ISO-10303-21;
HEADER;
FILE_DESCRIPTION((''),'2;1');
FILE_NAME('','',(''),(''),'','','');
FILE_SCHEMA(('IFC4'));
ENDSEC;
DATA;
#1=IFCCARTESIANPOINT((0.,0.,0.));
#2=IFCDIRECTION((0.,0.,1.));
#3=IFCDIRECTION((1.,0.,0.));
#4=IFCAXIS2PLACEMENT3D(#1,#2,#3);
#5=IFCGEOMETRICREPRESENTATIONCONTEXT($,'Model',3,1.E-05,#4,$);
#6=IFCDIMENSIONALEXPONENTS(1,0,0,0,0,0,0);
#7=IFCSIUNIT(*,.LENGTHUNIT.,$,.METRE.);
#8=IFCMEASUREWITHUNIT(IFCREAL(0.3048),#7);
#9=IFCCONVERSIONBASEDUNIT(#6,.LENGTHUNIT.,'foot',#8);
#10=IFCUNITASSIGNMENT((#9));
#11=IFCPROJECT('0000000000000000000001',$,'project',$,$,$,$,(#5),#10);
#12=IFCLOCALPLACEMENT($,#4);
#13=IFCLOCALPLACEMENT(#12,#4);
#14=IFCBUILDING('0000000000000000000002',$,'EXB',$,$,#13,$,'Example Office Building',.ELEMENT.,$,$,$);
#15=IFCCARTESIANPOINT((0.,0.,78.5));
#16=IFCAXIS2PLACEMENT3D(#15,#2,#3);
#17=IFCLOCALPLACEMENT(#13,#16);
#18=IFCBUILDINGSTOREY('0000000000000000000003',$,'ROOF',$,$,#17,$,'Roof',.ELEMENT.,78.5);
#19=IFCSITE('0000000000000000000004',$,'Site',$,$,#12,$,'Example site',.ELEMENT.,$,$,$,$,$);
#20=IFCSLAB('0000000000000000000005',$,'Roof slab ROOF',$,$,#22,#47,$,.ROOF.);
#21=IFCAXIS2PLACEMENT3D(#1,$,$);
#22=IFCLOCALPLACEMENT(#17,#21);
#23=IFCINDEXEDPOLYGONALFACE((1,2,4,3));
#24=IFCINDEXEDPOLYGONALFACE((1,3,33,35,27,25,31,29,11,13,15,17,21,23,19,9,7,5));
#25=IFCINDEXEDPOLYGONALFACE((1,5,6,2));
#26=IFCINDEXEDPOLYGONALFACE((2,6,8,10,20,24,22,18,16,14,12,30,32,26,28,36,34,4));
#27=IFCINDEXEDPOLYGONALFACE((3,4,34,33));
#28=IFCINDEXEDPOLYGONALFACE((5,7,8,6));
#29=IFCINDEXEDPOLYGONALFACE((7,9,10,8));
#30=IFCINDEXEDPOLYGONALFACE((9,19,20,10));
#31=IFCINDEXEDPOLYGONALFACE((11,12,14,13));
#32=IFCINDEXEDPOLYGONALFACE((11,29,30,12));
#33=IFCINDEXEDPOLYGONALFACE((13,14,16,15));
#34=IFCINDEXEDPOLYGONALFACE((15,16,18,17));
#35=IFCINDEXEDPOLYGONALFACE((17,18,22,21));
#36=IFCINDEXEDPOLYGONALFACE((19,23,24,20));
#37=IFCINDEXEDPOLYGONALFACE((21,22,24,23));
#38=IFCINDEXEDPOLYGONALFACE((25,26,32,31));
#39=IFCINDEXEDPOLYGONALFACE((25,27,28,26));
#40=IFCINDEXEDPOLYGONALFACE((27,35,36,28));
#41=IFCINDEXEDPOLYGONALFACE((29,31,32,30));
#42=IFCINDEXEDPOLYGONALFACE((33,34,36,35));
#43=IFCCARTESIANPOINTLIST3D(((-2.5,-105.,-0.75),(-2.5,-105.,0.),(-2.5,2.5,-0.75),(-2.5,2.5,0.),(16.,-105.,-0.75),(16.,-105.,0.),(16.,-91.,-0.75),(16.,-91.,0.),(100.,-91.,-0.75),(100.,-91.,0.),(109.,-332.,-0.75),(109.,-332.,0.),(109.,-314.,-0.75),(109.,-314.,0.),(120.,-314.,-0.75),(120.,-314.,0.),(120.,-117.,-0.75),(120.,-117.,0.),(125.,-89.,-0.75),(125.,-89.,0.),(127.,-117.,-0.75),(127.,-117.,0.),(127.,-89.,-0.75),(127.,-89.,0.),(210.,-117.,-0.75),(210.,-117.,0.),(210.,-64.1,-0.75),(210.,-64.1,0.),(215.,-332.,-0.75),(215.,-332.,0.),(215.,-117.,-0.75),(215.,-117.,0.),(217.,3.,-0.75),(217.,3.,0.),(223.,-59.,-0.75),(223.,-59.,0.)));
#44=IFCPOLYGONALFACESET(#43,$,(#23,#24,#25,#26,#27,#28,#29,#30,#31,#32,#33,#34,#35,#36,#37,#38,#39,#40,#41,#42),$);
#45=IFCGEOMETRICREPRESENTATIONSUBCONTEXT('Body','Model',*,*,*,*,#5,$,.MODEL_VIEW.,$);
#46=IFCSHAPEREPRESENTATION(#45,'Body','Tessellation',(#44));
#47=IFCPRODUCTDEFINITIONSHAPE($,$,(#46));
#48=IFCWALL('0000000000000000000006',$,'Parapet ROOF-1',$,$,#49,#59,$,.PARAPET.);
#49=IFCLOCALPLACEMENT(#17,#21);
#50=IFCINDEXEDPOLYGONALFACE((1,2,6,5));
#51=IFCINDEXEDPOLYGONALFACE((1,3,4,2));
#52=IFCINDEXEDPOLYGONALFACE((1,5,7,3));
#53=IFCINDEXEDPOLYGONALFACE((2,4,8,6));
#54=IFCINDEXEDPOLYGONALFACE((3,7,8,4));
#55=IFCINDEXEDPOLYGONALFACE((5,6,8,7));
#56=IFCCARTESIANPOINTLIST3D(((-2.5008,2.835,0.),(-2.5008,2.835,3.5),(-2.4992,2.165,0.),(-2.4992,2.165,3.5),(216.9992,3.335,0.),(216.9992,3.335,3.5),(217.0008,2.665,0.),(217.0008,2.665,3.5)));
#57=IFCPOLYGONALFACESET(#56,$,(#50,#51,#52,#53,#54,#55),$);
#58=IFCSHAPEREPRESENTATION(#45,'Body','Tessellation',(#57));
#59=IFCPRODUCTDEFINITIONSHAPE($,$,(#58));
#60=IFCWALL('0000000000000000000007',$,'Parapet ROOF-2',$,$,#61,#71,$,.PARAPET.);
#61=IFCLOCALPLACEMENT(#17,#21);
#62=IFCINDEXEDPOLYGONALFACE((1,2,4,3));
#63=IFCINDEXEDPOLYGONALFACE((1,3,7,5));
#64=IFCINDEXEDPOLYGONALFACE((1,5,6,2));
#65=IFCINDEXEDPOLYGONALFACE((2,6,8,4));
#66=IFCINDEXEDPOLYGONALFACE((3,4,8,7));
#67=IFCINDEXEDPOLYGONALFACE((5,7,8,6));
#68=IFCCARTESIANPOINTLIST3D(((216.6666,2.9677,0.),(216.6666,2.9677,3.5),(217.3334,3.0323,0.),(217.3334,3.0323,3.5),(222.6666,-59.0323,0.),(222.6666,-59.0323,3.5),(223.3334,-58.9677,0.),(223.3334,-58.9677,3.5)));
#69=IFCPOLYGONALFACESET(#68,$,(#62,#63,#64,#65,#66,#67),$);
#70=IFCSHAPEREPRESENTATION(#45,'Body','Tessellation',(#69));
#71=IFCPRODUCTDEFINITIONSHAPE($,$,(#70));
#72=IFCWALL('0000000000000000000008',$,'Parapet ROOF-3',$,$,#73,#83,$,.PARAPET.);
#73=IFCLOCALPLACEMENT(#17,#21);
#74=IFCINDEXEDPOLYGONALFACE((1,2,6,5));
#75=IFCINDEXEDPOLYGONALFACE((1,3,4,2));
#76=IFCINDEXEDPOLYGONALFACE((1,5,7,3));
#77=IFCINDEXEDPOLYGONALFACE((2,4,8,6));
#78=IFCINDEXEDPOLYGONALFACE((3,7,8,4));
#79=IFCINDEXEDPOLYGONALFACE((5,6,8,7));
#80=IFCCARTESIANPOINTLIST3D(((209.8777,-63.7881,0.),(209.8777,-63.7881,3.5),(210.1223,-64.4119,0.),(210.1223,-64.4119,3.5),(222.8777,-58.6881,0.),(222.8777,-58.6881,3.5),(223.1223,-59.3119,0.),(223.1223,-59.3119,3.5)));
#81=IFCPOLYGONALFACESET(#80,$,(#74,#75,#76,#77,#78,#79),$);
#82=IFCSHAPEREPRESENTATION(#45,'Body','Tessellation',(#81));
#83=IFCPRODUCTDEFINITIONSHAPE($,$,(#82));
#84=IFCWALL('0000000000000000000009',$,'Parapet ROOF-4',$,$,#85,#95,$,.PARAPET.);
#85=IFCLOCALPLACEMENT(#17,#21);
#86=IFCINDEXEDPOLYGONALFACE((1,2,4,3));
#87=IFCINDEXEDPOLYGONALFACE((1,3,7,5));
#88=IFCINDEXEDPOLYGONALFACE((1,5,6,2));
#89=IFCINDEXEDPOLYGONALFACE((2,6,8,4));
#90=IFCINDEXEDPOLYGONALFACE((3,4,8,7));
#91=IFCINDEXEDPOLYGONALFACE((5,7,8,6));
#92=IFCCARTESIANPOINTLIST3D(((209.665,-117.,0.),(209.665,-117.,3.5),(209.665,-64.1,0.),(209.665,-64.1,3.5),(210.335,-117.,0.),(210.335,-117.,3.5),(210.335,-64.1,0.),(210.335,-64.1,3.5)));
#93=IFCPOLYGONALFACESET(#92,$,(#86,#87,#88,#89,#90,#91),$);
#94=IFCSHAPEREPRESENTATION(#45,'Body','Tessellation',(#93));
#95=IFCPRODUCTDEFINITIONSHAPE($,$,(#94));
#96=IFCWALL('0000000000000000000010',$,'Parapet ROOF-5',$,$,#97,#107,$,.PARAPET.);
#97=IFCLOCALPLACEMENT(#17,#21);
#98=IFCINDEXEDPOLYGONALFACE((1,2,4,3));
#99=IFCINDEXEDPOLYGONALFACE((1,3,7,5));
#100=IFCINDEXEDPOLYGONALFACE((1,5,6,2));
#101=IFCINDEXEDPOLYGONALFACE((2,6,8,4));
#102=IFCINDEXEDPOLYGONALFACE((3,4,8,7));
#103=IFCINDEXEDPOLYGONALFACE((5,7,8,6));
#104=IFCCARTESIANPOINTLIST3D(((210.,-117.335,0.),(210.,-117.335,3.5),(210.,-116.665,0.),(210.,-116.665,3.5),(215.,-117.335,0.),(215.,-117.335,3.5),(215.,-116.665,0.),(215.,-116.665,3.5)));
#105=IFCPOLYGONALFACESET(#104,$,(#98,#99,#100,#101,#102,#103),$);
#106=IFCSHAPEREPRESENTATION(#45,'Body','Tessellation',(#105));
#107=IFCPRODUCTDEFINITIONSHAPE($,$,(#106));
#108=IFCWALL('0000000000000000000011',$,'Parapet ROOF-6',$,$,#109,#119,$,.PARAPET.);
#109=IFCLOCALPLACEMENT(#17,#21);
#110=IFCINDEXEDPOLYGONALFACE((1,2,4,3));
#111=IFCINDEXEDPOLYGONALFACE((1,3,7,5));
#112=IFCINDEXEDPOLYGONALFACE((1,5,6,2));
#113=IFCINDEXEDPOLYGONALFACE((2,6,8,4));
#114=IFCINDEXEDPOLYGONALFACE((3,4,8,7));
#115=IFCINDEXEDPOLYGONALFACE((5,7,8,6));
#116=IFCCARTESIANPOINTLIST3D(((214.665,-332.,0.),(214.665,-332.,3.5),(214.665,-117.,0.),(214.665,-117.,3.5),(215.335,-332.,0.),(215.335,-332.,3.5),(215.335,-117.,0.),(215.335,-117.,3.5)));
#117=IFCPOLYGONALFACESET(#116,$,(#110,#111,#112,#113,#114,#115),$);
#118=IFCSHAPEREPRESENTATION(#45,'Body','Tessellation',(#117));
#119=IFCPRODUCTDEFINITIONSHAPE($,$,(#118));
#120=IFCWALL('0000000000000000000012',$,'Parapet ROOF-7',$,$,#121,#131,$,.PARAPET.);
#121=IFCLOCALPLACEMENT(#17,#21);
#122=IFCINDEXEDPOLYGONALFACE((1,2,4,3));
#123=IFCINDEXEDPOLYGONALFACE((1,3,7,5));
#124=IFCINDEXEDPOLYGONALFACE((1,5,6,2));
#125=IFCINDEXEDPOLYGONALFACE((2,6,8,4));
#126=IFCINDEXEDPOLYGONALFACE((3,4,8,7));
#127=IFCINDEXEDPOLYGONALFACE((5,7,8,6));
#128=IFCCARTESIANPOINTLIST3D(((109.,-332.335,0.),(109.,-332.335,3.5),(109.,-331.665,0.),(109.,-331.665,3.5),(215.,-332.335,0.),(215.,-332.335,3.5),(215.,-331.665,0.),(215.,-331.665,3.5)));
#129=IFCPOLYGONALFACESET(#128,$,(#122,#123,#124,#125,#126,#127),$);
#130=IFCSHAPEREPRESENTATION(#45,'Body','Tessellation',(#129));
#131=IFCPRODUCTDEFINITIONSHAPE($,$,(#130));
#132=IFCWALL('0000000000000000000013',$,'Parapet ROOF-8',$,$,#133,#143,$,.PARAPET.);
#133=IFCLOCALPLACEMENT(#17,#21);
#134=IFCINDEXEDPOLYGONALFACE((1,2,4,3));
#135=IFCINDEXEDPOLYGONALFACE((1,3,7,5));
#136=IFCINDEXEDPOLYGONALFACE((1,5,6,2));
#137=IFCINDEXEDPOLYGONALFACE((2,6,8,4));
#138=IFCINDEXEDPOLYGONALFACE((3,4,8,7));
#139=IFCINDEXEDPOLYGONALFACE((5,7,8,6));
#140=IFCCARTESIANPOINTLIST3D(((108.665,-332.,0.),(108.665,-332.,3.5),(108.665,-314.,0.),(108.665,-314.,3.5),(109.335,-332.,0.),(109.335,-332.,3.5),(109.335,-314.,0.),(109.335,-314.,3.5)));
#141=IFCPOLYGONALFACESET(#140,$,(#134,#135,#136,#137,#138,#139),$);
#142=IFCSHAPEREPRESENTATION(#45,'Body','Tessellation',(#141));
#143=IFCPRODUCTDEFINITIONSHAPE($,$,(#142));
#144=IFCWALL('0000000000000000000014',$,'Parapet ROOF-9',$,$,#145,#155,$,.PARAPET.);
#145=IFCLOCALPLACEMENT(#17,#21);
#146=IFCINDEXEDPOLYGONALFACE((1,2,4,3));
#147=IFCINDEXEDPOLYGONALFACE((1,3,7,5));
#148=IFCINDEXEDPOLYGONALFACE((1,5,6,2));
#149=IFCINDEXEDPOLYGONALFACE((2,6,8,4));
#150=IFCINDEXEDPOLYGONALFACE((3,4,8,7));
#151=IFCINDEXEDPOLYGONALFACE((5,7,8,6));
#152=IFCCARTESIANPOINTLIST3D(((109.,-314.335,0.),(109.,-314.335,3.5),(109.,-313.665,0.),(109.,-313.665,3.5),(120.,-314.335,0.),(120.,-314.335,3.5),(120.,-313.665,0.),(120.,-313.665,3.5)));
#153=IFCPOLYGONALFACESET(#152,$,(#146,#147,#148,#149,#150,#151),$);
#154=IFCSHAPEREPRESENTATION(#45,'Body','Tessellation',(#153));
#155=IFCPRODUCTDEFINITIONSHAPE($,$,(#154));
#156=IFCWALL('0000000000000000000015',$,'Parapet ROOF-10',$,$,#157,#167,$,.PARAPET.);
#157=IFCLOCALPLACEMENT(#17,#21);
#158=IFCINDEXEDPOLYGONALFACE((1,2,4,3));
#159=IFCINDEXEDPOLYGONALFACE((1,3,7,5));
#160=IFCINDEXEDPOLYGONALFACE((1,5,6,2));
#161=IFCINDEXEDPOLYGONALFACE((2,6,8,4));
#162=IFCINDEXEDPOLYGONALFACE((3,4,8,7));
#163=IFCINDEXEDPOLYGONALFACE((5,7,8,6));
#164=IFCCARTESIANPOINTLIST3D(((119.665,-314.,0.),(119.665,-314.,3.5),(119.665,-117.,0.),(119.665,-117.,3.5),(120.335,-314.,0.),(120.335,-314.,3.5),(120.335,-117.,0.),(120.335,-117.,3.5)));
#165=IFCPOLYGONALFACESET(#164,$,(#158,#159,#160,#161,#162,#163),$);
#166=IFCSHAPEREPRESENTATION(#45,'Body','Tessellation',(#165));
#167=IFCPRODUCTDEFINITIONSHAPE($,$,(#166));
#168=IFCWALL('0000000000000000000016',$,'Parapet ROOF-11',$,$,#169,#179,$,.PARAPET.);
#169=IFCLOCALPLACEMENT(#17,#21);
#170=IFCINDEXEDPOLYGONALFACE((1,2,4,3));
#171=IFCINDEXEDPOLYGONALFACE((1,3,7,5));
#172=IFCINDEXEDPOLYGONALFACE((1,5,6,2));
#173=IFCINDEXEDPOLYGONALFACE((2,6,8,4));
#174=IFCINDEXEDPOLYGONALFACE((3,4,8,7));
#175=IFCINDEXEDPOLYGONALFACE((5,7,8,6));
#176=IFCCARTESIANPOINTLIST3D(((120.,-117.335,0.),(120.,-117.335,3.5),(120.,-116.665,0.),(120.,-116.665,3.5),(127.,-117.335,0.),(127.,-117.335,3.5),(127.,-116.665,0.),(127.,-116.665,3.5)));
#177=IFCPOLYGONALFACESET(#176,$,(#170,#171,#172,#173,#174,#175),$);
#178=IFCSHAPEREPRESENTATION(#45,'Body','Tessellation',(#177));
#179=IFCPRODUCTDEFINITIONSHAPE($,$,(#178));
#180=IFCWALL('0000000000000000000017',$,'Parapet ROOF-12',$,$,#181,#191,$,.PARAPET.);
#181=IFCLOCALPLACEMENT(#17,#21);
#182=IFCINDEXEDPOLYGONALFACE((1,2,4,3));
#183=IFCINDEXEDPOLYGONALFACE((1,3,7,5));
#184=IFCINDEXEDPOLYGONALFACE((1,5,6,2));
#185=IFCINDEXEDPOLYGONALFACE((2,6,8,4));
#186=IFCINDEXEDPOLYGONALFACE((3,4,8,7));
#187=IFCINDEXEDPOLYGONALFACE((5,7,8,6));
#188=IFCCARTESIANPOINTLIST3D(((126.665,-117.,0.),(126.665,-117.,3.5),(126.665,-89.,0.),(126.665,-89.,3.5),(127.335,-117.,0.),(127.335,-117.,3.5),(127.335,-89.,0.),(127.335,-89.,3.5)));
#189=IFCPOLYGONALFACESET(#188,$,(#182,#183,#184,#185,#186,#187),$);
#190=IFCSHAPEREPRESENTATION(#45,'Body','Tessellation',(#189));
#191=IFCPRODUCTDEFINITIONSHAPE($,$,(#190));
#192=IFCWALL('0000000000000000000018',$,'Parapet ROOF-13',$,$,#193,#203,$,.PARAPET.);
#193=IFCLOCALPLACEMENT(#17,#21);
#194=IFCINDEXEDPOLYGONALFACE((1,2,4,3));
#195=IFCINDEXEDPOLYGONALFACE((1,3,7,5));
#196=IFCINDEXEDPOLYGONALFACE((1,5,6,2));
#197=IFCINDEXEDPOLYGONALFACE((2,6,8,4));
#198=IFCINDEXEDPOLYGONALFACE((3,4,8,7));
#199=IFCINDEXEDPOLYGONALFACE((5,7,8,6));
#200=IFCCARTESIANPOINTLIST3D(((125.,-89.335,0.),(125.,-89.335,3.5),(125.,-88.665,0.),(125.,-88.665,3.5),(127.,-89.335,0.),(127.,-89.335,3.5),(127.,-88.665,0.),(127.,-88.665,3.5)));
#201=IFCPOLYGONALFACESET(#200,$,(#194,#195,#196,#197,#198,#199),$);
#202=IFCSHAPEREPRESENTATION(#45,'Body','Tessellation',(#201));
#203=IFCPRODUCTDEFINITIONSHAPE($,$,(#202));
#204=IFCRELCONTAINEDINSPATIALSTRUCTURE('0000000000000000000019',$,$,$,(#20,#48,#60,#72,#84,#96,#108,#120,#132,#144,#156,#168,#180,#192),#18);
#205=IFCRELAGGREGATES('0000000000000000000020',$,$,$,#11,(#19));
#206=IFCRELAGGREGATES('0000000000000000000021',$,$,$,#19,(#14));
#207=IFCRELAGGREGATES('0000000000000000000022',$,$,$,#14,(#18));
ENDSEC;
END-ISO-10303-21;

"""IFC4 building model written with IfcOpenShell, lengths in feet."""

from ifc_helpers import new_model, entity, si_unit, converted_unit, frame, frame_2d, origin, origin_with_axes, place, context, subcontext, project, spatial, polyline, rectangle, outline, extrude, element, save


model = new_model("IFC4")

# Units and contexts
model_context = context("Model", 3, precision=1e-05, world=origin_with_axes())
body_context = subcontext(model_context, "Body", "Model", "MODEL_VIEW")
ifc_project = project(units=[converted_unit("LENGTHUNIT", "foot", entity("IfcReal", 0.3048), si_unit("LENGTHUNIT", "METRE"), dimensions=[1, 0, 0, 0, 0, 0, 0])], contexts=[model_context])

# Site, building, storey
site_placement = place(None, origin_with_axes())
site = spatial("IfcSite", under=ifc_project, at=site_placement, Name="Site", LongName="Example site", CompositionType="ELEMENT")
building_placement = place(site_placement, origin_with_axes())
building = spatial("IfcBuilding", under=site, at=building_placement, Name="EXB", LongName="Example Office Building", CompositionType="ELEMENT")
storey_placement = place(building_placement, frame((0.0, 0.0, 78.5), z_axis=(0.0, 0.0, 1.0), x_axis=(1.0, 0.0, 0.0)))
storey = spatial("IfcBuildingStorey", under=building, at=storey_placement, Name="ROOF", LongName="Roof", CompositionType="ELEMENT", Elevation=78.5)

# Slab
slab_placement = place(storey_placement, origin_with_axes())
element("IfcSlab", 1, at=slab_placement, inside=storey, Name="Roof slab ROOF", PredefinedType="ROOF", context=body_context, shape_type="SweptSolid", body=[
    extrude(outline(polyline([(-2.5, 2.5), (217.0, 3.0), (223.0, -59.0), (210.0, -64.1), (210.0, -117.0), (215.0, -117.0), (215.0, -332.0), (109.0, -332.0), (109.0, -314.0), (120.0, -314.0), (120.0, -117.0), (127.0, -117.0), (127.0, -89.0), (125.0, -89.0), (100.0, -91.0), (16.0, -91.0), (16.0, -105.0), (-2.5, -105.0), (-2.5, 2.5)])), frame((0.0, 0.0, -0.75)), (0.0, 0.0, 1.0), 0.75),
])

# Walls
wall_1_placement = place(storey_placement, frame((-2.5, 2.5, 0.0), z_axis=(0.0, 0.0, 1.0), x_axis=(0.999997, 0.002278, 0.0)))
element("IfcWall", 2, at=wall_1_placement, inside=storey, Name="Parapet ROOF-1", PredefinedType="PARAPET", context=body_context, shape_type="SweptSolid", body=[
    extrude(rectangle(XDim=219.5006, YDim=0.67, at=frame_2d((109.7503, 0.0))), origin(), (0.0, 0.0, 1.0), 3.5),
])
wall_2_placement = place(storey_placement, frame((217.0, 3.0, 0.0), z_axis=(0.0, 0.0, 1.0), x_axis=(0.096324, -0.99535, 0.0)))
element("IfcWall", 3, at=wall_2_placement, inside=storey, Name="Parapet ROOF-2", PredefinedType="PARAPET", context=body_context, shape_type="SweptSolid", body=[
    extrude(rectangle(XDim=62.2896, YDim=0.67, at=frame_2d((31.1448, 0.0))), origin(), (0.0, 0.0, 1.0), 3.5),
])
wall_3_placement = place(storey_placement, frame((223.0, -59.0, 0.0), z_axis=(0.0, 0.0, 1.0), x_axis=(-0.930925, -0.365209, 0.0)))
element("IfcWall", 4, at=wall_3_placement, inside=storey, Name="Parapet ROOF-3", PredefinedType="PARAPET", context=body_context, shape_type="SweptSolid", body=[
    extrude(rectangle(XDim=13.9646, YDim=0.67, at=frame_2d((6.9823, 0.0))), origin(), (0.0, 0.0, 1.0), 3.5),
])
wall_4_placement = place(storey_placement, frame((210.0, -64.1, 0.0), z_axis=(0.0, 0.0, 1.0), x_axis=(0.0, -1.0, 0.0)))
element("IfcWall", 5, at=wall_4_placement, inside=storey, Name="Parapet ROOF-4", PredefinedType="PARAPET", context=body_context, shape_type="SweptSolid", body=[
    extrude(rectangle(XDim=52.9, YDim=0.67, at=frame_2d((26.45, 0.0))), origin(), (0.0, 0.0, 1.0), 3.5),
])
wall_5_placement = place(storey_placement, frame((210.0, -117.0, 0.0), z_axis=(0.0, 0.0, 1.0), x_axis=(1.0, 0.0, 0.0)))
element("IfcWall", 6, at=wall_5_placement, inside=storey, Name="Parapet ROOF-5", PredefinedType="PARAPET", context=body_context, shape_type="SweptSolid", body=[
    extrude(rectangle(XDim=5.0, YDim=0.67, at=frame_2d((2.5, 0.0))), origin(), (0.0, 0.0, 1.0), 3.5),
])
wall_6_placement = place(storey_placement, frame((215.0, -117.0, 0.0), z_axis=(0.0, 0.0, 1.0), x_axis=(0.0, -1.0, 0.0)))
element("IfcWall", 7, at=wall_6_placement, inside=storey, Name="Parapet ROOF-6", PredefinedType="PARAPET", context=body_context, shape_type="SweptSolid", body=[
    extrude(rectangle(XDim=215.0, YDim=0.67, at=frame_2d((107.5, 0.0))), origin(), (0.0, 0.0, 1.0), 3.5),
])
wall_7_placement = place(storey_placement, frame((215.0, -332.0, 0.0), z_axis=(0.0, 0.0, 1.0), x_axis=(-1.0, 0.0, 0.0)))
element("IfcWall", 8, at=wall_7_placement, inside=storey, Name="Parapet ROOF-7", PredefinedType="PARAPET", context=body_context, shape_type="SweptSolid", body=[
    extrude(rectangle(XDim=106.0, YDim=0.67, at=frame_2d((53.0, 0.0))), origin(), (0.0, 0.0, 1.0), 3.5),
])
wall_8_placement = place(storey_placement, frame((109.0, -332.0, 0.0), z_axis=(0.0, 0.0, 1.0), x_axis=(0.0, 1.0, 0.0)))
element("IfcWall", 9, at=wall_8_placement, inside=storey, Name="Parapet ROOF-8", PredefinedType="PARAPET", context=body_context, shape_type="SweptSolid", body=[
    extrude(rectangle(XDim=18.0, YDim=0.67, at=frame_2d((9.0, 0.0))), origin(), (0.0, 0.0, 1.0), 3.5),
])
wall_9_placement = place(storey_placement, frame((109.0, -314.0, 0.0), z_axis=(0.0, 0.0, 1.0), x_axis=(1.0, 0.0, 0.0)))
element("IfcWall", 10, at=wall_9_placement, inside=storey, Name="Parapet ROOF-9", PredefinedType="PARAPET", context=body_context, shape_type="SweptSolid", body=[
    extrude(rectangle(XDim=11.0, YDim=0.67, at=frame_2d((5.5, 0.0))), origin(), (0.0, 0.0, 1.0), 3.5),
])
wall_10_placement = place(storey_placement, frame((120.0, -314.0, 0.0), z_axis=(0.0, 0.0, 1.0), x_axis=(0.0, 1.0, 0.0)))
element("IfcWall", 11, at=wall_10_placement, inside=storey, Name="Parapet ROOF-10", PredefinedType="PARAPET", context=body_context, shape_type="SweptSolid", body=[
    extrude(rectangle(XDim=197.0, YDim=0.67, at=frame_2d((98.5, 0.0))), origin(), (0.0, 0.0, 1.0), 3.5),
])
wall_11_placement = place(storey_placement, frame((120.0, -117.0, 0.0), z_axis=(0.0, 0.0, 1.0), x_axis=(1.0, 0.0, 0.0)))
element("IfcWall", 12, at=wall_11_placement, inside=storey, Name="Parapet ROOF-11", PredefinedType="PARAPET", context=body_context, shape_type="SweptSolid", body=[
    extrude(rectangle(XDim=7.0, YDim=0.67, at=frame_2d((3.5, 0.0))), origin(), (0.0, 0.0, 1.0), 3.5),
])
wall_12_placement = place(storey_placement, frame((127.0, -117.0, 0.0), z_axis=(0.0, 0.0, 1.0), x_axis=(0.0, 1.0, 0.0)))
element("IfcWall", 13, at=wall_12_placement, inside=storey, Name="Parapet ROOF-12", PredefinedType="PARAPET", context=body_context, shape_type="SweptSolid", body=[
    extrude(rectangle(XDim=28.0, YDim=0.67, at=frame_2d((14.0, 0.0))), origin(), (0.0, 0.0, 1.0), 3.5),
])
wall_13_placement = place(storey_placement, frame((127.0, -89.0, 0.0), z_axis=(0.0, 0.0, 1.0), x_axis=(-1.0, 0.0, 0.0)))
element("IfcWall", 14, at=wall_13_placement, inside=storey, Name="Parapet ROOF-13", PredefinedType="PARAPET", context=body_context, shape_type="SweptSolid", body=[
    extrude(rectangle(XDim=2.0, YDim=0.67, at=frame_2d((1.0, 0.0))), origin(), (0.0, 0.0, 1.0), 3.5),
])

save(model, "model.ifc")
